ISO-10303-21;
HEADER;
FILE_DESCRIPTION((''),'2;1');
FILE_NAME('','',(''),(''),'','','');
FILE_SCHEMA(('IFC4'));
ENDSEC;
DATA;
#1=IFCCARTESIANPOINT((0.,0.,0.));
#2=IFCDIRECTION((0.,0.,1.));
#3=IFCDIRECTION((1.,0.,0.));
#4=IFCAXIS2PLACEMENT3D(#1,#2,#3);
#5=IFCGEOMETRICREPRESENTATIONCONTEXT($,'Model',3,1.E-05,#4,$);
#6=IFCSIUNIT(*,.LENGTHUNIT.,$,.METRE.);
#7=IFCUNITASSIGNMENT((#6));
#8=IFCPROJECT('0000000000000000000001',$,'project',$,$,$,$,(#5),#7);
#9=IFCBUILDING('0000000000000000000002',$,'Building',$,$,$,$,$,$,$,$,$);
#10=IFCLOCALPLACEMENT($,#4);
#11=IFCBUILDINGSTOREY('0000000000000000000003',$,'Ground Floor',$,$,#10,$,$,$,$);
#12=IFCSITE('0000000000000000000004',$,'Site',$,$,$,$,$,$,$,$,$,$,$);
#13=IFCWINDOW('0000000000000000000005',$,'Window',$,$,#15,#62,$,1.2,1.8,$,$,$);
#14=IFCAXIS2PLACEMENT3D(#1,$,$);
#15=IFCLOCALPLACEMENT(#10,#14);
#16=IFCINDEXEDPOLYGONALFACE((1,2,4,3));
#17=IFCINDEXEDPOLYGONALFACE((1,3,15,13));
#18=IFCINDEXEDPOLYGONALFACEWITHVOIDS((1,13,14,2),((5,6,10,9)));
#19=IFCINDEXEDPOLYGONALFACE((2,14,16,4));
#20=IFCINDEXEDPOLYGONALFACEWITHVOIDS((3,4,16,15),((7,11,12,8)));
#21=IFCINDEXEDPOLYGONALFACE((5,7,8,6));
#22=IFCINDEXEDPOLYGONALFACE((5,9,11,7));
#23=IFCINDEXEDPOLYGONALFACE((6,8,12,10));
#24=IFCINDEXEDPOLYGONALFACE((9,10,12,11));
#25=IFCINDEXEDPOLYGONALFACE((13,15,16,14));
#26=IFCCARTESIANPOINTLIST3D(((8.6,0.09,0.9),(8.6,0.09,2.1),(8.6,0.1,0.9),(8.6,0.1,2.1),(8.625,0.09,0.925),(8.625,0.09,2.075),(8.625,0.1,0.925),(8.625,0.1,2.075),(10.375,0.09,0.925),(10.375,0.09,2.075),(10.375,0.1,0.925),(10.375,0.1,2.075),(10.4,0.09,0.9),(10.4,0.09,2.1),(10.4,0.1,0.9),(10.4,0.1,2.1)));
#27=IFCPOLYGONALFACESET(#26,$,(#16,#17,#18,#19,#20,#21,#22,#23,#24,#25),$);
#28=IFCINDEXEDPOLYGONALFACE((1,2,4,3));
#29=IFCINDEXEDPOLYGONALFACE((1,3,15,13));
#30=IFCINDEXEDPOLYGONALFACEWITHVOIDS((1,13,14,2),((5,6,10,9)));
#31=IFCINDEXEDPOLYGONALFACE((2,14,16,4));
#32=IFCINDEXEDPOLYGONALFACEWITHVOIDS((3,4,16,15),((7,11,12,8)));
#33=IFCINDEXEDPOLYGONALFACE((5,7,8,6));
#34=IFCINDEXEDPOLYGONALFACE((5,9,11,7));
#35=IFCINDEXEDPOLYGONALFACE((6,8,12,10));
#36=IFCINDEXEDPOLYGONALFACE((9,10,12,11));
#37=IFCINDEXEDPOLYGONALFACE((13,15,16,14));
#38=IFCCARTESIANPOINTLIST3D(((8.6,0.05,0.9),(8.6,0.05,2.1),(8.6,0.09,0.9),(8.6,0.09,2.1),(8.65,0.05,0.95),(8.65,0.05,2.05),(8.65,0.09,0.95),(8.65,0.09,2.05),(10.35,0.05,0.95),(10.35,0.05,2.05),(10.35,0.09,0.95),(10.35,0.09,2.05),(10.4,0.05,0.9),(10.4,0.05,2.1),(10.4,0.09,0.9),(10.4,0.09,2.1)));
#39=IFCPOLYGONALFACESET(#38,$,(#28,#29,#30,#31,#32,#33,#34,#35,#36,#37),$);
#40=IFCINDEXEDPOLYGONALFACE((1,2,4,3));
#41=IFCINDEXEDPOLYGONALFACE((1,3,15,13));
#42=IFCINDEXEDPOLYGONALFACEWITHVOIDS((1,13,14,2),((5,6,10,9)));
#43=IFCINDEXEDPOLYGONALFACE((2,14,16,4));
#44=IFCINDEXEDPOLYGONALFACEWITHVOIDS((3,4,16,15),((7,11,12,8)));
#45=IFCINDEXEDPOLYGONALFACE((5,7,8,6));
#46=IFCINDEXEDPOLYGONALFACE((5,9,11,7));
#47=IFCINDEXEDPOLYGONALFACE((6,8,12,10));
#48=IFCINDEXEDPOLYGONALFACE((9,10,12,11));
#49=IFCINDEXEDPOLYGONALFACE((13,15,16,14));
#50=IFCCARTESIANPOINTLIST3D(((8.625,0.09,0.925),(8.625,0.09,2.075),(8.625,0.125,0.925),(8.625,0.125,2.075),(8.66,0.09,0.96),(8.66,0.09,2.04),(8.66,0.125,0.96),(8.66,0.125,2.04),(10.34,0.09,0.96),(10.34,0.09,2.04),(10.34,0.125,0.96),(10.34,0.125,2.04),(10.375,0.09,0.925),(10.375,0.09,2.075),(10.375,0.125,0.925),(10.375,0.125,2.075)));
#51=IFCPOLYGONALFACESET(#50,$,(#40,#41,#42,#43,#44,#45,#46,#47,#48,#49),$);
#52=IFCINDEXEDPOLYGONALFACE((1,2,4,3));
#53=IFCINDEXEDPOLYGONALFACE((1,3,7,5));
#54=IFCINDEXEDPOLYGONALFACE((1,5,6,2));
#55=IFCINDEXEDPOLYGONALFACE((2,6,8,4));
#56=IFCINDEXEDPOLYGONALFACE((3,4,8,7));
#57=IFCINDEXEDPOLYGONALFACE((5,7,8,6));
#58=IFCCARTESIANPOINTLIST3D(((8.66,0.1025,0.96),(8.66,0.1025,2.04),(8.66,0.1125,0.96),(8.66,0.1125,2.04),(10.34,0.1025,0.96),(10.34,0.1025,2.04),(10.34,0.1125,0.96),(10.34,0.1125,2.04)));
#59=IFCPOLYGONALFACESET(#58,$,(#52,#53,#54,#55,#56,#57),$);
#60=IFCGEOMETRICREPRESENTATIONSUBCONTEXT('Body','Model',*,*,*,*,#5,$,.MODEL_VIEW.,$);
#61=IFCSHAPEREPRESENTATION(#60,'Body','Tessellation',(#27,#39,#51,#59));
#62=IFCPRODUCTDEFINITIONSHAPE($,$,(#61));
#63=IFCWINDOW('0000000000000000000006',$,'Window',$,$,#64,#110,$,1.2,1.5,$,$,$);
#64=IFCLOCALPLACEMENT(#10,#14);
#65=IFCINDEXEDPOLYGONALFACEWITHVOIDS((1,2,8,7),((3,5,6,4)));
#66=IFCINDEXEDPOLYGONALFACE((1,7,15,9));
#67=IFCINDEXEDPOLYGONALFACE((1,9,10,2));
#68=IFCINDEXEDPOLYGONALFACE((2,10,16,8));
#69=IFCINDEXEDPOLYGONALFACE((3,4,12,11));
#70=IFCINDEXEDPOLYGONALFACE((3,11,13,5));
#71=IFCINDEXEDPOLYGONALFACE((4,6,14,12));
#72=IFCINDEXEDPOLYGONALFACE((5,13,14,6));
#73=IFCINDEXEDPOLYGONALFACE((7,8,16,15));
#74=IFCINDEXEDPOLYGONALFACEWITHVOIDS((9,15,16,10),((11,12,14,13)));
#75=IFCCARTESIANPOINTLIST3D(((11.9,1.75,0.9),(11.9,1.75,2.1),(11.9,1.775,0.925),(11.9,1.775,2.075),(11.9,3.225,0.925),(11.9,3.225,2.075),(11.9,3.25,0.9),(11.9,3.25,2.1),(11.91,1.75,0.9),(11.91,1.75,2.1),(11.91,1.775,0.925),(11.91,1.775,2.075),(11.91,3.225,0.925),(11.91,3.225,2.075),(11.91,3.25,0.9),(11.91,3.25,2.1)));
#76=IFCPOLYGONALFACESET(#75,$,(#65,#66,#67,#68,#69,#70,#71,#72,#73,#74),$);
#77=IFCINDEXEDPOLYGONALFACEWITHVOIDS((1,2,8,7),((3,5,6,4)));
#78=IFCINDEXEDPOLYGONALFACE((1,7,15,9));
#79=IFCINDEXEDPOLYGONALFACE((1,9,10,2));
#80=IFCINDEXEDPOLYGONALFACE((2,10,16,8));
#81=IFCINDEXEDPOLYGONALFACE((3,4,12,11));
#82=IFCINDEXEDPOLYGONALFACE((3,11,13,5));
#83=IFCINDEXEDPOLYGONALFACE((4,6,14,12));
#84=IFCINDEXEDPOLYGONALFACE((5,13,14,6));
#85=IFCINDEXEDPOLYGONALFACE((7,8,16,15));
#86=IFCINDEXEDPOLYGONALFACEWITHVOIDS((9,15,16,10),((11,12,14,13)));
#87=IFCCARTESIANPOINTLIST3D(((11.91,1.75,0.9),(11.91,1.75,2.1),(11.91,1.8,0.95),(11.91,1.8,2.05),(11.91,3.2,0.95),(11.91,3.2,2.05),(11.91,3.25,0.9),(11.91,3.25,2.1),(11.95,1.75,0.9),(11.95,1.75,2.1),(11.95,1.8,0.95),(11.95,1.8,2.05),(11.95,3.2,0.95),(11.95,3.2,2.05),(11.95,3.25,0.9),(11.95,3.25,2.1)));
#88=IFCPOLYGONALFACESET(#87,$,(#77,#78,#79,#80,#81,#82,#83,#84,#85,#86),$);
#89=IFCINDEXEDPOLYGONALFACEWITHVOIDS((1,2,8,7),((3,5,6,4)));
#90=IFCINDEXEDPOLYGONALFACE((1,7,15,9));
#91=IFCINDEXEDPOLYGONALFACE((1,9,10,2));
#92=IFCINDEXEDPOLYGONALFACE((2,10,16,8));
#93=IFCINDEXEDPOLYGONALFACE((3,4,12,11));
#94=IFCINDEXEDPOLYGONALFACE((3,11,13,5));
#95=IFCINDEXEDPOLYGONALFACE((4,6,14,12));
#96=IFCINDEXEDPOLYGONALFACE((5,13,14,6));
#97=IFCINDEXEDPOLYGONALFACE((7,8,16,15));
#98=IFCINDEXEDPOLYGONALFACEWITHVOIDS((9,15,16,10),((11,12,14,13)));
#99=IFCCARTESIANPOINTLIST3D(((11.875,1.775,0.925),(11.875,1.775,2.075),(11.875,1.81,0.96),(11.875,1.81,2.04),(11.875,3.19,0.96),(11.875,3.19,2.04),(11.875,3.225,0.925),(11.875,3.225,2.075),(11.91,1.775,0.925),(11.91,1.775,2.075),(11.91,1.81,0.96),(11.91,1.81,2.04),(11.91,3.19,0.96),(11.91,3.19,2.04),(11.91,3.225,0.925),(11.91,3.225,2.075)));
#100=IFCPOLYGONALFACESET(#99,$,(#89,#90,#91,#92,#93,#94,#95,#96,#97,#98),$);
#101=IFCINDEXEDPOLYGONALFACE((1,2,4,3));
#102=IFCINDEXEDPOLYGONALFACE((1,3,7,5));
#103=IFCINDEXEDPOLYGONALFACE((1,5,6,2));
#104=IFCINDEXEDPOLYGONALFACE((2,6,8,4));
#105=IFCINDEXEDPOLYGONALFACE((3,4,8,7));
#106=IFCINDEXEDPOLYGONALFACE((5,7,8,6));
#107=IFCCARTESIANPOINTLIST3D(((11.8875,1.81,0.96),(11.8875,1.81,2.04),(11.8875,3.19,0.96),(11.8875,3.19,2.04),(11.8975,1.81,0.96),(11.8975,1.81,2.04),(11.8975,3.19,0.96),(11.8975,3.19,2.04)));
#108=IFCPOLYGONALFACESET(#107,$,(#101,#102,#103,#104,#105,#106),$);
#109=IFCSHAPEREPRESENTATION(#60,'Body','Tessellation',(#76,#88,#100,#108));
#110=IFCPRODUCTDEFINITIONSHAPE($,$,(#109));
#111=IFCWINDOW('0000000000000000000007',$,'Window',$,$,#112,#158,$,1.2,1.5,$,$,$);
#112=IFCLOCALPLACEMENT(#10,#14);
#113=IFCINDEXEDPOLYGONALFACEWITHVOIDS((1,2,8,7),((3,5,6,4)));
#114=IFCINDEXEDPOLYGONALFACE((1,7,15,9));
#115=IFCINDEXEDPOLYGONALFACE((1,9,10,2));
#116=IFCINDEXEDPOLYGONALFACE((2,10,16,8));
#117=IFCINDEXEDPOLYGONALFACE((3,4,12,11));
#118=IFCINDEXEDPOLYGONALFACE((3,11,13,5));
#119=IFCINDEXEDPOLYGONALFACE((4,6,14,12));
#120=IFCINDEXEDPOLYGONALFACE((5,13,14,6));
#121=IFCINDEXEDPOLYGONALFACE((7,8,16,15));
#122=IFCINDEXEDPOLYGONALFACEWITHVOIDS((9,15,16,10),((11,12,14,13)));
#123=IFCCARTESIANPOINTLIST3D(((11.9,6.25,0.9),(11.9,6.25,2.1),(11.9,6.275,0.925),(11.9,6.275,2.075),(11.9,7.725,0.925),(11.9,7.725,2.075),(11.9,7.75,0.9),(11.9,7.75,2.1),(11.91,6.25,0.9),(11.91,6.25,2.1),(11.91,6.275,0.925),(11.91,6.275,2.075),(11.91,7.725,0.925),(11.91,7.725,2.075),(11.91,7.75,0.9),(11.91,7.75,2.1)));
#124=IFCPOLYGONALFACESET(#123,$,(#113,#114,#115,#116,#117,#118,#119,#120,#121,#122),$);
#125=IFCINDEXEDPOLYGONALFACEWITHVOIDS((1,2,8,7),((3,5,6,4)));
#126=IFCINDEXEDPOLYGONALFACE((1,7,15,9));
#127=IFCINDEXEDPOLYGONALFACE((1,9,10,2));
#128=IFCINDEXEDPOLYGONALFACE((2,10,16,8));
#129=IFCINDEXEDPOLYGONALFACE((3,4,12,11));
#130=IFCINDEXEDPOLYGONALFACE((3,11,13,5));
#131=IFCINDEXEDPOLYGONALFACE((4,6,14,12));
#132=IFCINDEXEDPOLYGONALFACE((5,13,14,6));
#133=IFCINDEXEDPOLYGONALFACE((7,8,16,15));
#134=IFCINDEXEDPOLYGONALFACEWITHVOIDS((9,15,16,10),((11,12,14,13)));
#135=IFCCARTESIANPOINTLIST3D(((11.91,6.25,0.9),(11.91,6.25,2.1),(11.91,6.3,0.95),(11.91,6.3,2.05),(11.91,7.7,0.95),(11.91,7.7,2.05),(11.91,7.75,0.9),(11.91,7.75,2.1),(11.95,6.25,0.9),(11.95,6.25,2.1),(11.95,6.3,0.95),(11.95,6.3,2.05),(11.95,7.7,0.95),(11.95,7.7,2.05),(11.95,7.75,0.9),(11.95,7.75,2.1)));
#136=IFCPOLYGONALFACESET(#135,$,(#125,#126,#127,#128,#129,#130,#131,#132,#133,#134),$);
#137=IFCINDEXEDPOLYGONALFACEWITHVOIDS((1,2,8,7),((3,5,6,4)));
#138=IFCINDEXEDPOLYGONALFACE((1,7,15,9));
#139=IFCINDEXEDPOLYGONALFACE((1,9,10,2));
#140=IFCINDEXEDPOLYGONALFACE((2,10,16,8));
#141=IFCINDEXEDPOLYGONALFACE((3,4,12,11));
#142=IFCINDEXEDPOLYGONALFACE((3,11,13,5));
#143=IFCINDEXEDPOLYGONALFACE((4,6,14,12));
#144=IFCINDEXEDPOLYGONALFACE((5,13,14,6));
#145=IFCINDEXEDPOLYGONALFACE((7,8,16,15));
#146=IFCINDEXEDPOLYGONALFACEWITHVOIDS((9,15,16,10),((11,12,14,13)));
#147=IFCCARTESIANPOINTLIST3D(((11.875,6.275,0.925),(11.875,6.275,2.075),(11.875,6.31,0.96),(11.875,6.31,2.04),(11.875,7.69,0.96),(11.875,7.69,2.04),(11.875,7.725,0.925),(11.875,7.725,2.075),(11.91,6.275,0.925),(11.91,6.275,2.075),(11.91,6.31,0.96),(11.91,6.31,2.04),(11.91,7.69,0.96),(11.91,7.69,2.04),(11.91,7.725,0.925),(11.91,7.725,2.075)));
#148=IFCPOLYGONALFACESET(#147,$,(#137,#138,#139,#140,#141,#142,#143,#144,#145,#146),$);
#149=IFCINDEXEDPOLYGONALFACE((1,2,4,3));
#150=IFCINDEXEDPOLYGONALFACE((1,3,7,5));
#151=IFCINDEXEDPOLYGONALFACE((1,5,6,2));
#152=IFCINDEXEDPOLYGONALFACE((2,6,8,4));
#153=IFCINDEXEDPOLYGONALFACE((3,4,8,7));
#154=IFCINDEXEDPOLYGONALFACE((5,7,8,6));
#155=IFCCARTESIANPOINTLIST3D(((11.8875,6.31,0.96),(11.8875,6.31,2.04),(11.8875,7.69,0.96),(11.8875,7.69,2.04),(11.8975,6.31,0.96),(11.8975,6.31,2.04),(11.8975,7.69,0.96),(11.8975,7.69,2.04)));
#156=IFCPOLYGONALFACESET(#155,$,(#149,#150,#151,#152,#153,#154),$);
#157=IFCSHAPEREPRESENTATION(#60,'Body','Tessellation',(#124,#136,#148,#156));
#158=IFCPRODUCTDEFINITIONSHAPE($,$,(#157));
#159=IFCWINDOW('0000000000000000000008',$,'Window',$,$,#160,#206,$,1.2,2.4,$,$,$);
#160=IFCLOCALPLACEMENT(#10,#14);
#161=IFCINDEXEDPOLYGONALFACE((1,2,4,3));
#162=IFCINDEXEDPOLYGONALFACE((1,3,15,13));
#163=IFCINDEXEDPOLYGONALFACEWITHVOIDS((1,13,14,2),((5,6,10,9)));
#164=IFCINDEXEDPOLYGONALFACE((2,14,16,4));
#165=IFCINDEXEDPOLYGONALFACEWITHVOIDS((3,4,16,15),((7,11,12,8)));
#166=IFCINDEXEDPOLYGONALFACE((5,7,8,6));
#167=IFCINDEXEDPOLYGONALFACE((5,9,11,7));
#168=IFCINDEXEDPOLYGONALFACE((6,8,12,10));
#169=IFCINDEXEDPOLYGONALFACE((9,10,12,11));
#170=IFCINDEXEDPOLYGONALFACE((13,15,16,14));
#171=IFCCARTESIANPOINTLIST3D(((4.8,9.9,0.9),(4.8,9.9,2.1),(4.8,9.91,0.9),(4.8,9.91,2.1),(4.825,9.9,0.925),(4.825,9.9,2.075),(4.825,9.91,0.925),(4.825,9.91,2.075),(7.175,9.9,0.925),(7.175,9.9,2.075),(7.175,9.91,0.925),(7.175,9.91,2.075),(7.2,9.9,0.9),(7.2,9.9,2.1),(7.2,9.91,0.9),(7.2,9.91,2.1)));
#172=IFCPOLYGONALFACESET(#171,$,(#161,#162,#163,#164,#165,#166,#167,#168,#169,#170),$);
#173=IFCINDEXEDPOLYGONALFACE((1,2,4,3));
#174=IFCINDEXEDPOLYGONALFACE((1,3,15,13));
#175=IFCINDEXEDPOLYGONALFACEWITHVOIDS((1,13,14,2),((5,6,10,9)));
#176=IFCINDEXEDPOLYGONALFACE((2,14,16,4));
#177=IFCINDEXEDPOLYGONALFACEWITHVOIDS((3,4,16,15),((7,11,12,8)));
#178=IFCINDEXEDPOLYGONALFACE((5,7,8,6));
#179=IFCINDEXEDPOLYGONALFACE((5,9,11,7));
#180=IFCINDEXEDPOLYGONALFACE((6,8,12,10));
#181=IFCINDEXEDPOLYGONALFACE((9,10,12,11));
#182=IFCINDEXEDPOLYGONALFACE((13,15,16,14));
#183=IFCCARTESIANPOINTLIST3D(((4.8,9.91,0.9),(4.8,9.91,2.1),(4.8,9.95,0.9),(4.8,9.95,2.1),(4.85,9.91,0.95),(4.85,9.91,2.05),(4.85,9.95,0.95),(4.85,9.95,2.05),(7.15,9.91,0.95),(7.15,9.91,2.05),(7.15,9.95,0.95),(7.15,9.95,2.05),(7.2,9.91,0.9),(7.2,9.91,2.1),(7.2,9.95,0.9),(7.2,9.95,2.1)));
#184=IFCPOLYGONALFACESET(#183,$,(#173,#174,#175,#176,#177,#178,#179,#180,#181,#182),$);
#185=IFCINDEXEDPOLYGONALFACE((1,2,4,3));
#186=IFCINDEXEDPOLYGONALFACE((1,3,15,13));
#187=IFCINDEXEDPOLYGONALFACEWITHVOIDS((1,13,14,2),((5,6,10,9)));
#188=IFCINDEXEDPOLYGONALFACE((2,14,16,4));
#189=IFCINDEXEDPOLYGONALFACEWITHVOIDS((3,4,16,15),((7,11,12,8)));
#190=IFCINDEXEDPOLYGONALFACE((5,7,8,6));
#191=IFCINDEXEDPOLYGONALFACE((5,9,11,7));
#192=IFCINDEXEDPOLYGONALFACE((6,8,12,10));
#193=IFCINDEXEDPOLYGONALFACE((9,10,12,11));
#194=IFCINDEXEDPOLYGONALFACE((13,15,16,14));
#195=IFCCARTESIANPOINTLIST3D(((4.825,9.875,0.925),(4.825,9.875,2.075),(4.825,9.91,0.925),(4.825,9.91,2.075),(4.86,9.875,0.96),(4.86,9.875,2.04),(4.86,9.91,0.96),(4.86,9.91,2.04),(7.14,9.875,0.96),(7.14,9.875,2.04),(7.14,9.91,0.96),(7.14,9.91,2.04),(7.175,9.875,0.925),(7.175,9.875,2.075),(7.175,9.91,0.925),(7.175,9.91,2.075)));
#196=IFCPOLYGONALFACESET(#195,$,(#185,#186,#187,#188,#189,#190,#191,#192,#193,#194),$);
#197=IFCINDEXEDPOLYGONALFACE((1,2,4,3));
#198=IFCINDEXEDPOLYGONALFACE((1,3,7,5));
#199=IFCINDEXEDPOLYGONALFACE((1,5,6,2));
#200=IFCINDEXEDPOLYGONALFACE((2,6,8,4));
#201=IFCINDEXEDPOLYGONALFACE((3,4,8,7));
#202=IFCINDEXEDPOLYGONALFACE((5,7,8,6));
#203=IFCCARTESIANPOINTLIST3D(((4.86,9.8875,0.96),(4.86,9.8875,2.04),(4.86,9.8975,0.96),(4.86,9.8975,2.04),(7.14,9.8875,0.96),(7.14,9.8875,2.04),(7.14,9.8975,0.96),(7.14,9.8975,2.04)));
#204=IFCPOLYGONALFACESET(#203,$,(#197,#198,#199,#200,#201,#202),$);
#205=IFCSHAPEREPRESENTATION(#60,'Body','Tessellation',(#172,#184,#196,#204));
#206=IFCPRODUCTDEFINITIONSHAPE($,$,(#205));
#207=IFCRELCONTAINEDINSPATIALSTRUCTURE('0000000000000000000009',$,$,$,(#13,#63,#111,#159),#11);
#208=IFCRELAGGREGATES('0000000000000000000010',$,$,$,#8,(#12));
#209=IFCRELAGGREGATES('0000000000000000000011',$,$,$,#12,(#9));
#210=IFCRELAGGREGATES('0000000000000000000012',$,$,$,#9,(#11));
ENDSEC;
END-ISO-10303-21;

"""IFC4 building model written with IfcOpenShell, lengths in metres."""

from ifc_helpers import new_model, si_unit, frame, origin_with_axes, place, context, subcontext, project, spatial, line, indexed_curve, outline, extrude, element, save


model = new_model("IFC4")

# Units and contexts
model_context = context("Model", 3, precision=1e-05, world=origin_with_axes())
body_context = subcontext(model_context, "Body", "Model", "MODEL_VIEW")
ifc_project = project(units=[si_unit("LENGTHUNIT", "METRE")], contexts=[model_context])

# Site, building, storey
site = spatial("IfcSite", under=ifc_project, Name="Site")
building = spatial("IfcBuilding", under=site, Name="Building")
storey_placement = place(None, origin_with_axes())
storey = spatial("IfcBuildingStorey", under=building, at=storey_placement, Name="Ground Floor")

# Windows
window_1_placement = place(storey_placement, frame((8.6, 0.0, 0.9), z_axis=(0.0, 0.0, 1.0), x_axis=(1.0, 0.0, 0.0)))
element("IfcWindow", 1, at=window_1_placement, inside=storey, Name="Window", OverallHeight=1.2, OverallWidth=1.8, context=body_context, shape_type="SweptSolid", body=[
    extrude(outline(indexed_curve([(0.0, 0.0), (1.8, 0.0), (1.8, 1.2), (0.0, 1.2)], segments=[line(1, 2, 3, 4, 1)]), holes=[indexed_curve([(0.025, 0.025), (1.775, 0.025), (1.775, 1.175), (0.025, 1.175)], segments=[line(1, 2, 3, 4, 1)])]), frame((0.0, 0.09, 0.0), z_axis=(0.0, -1.0, 0.0), x_axis=(1.0, 0.0, 0.0)), (0.0, 0.0, -1.0), 0.01),
    extrude(outline(indexed_curve([(0.0, 0.0), (1.8, 0.0), (1.8, 1.2), (0.0, 1.2)], segments=[line(1, 2, 3, 4, 1)]), holes=[indexed_curve([(0.05, 0.05), (1.75, 0.05), (1.75, 1.15), (0.05, 1.15)], segments=[line(1, 2, 3, 4, 1)])]), frame((0.0, 0.05, 0.0), z_axis=(0.0, -1.0, 0.0), x_axis=(1.0, 0.0, 0.0)), (0.0, 0.0, -1.0), 0.04),
    extrude(outline(indexed_curve([(0.0, 0.0), (1.75, 0.0), (1.75, 1.15), (0.0, 1.15)], segments=[line(1, 2, 3, 4, 1)]), holes=[indexed_curve([(0.035, 0.035), (1.715, 0.035), (1.715, 1.115), (0.035, 1.115)], segments=[line(1, 2, 3, 4, 1)])]), frame((0.025, 0.09, 0.025), z_axis=(0.0, -1.0, 0.0), x_axis=(1.0, 0.0, 0.0)), (0.0, 0.0, -1.0), 0.035),
    extrude(outline(indexed_curve([(0.035, 0.035), (1.715, 0.035), (1.715, 1.115), (0.035, 1.115)], segments=[line(1, 2, 3, 4, 1)])), frame((0.025, 0.1025, 0.025), z_axis=(0.0, -1.0, 0.0), x_axis=(1.0, 0.0, 0.0)), (0.0, 0.0, -1.0), 0.01),
])
for number, where, z_axis, x_axis, name in (
    (2, (12.0, 1.75, 0.9), (0.0, 0.0, 1.0), (0.0, 1.0, 0.0), "Window"),
    (3, (12.0, 6.25, 0.9), (0.0, 0.0, 1.0), (0.0, 1.0, 0.0), "Window"),
):
    element("IfcWindow", number, at=place(storey_placement, frame(where, z_axis=z_axis, x_axis=x_axis)), inside=storey, Name=name, OverallHeight=1.2, OverallWidth=1.5, context=body_context, shape_type="SweptSolid", body=[
        extrude(outline(indexed_curve([(0.0, 0.0), (1.5, 0.0), (1.5, 1.2), (0.0, 1.2)], segments=[line(1, 2, 3, 4, 1)]), holes=[indexed_curve([(0.025, 0.025), (1.475, 0.025), (1.475, 1.175), (0.025, 1.175)], segments=[line(1, 2, 3, 4, 1)])]), frame((0.0, 0.09, 0.0), z_axis=(0.0, -1.0, 0.0), x_axis=(1.0, 0.0, 0.0)), (0.0, 0.0, -1.0), 0.01),
        extrude(outline(indexed_curve([(0.0, 0.0), (1.5, 0.0), (1.5, 1.2), (0.0, 1.2)], segments=[line(1, 2, 3, 4, 1)]), holes=[indexed_curve([(0.05, 0.05), (1.45, 0.05), (1.45, 1.15), (0.05, 1.15)], segments=[line(1, 2, 3, 4, 1)])]), frame((0.0, 0.05, 0.0), z_axis=(0.0, -1.0, 0.0), x_axis=(1.0, 0.0, 0.0)), (0.0, 0.0, -1.0), 0.04),
        extrude(outline(indexed_curve([(0.0, 0.0), (1.45, 0.0), (1.45, 1.15), (0.0, 1.15)], segments=[line(1, 2, 3, 4, 1)]), holes=[indexed_curve([(0.035, 0.035), (1.415, 0.035), (1.415, 1.115), (0.035, 1.115)], segments=[line(1, 2, 3, 4, 1)])]), frame((0.025, 0.09, 0.025), z_axis=(0.0, -1.0, 0.0), x_axis=(1.0, 0.0, 0.0)), (0.0, 0.0, -1.0), 0.035),
        extrude(outline(indexed_curve([(0.035, 0.035), (1.415, 0.035), (1.415, 1.115), (0.035, 1.115)], segments=[line(1, 2, 3, 4, 1)])), frame((0.025, 0.1025, 0.025), z_axis=(0.0, -1.0, 0.0), x_axis=(1.0, 0.0, 0.0)), (0.0, 0.0, -1.0), 0.01),
    ])
window_2_placement = place(storey_placement, frame((7.2, 10.0, 0.9), z_axis=(0.0, 0.0, 1.0), x_axis=(-1.0, 0.0, 0.0)))
element("IfcWindow", 4, at=window_2_placement, inside=storey, Name="Window", OverallHeight=1.2, OverallWidth=2.4, context=body_context, shape_type="SweptSolid", body=[
    extrude(outline(indexed_curve([(0.0, 0.0), (2.4, 0.0), (2.4, 1.2), (0.0, 1.2)], segments=[line(1, 2, 3, 4, 1)]), holes=[indexed_curve([(0.025, 0.025), (2.375, 0.025), (2.375, 1.175), (0.025, 1.175)], segments=[line(1, 2, 3, 4, 1)])]), frame((0.0, 0.09, 0.0), z_axis=(0.0, -1.0, 0.0), x_axis=(1.0, 0.0, 0.0)), (0.0, 0.0, -1.0), 0.01),
    extrude(outline(indexed_curve([(0.0, 0.0), (2.4, 0.0), (2.4, 1.2), (0.0, 1.2)], segments=[line(1, 2, 3, 4, 1)]), holes=[indexed_curve([(0.05, 0.05), (2.35, 0.05), (2.35, 1.15), (0.05, 1.15)], segments=[line(1, 2, 3, 4, 1)])]), frame((0.0, 0.05, 0.0), z_axis=(0.0, -1.0, 0.0), x_axis=(1.0, 0.0, 0.0)), (0.0, 0.0, -1.0), 0.04),
    extrude(outline(indexed_curve([(0.0, 0.0), (2.35, 0.0), (2.35, 1.15), (0.0, 1.15)], segments=[line(1, 2, 3, 4, 1)]), holes=[indexed_curve([(0.035, 0.035), (2.315, 0.035), (2.315, 1.115), (0.035, 1.115)], segments=[line(1, 2, 3, 4, 1)])]), frame((0.025, 0.09, 0.025), z_axis=(0.0, -1.0, 0.0), x_axis=(1.0, 0.0, 0.0)), (0.0, 0.0, -1.0), 0.035),
    extrude(outline(indexed_curve([(0.035, 0.035), (2.315, 0.035), (2.315, 1.115), (0.035, 1.115)], segments=[line(1, 2, 3, 4, 1)])), frame((0.025, 0.1025, 0.025), z_axis=(0.0, -1.0, 0.0), x_axis=(1.0, 0.0, 0.0)), (0.0, 0.0, -1.0), 0.01),
])

save(model, "model.ifc")
